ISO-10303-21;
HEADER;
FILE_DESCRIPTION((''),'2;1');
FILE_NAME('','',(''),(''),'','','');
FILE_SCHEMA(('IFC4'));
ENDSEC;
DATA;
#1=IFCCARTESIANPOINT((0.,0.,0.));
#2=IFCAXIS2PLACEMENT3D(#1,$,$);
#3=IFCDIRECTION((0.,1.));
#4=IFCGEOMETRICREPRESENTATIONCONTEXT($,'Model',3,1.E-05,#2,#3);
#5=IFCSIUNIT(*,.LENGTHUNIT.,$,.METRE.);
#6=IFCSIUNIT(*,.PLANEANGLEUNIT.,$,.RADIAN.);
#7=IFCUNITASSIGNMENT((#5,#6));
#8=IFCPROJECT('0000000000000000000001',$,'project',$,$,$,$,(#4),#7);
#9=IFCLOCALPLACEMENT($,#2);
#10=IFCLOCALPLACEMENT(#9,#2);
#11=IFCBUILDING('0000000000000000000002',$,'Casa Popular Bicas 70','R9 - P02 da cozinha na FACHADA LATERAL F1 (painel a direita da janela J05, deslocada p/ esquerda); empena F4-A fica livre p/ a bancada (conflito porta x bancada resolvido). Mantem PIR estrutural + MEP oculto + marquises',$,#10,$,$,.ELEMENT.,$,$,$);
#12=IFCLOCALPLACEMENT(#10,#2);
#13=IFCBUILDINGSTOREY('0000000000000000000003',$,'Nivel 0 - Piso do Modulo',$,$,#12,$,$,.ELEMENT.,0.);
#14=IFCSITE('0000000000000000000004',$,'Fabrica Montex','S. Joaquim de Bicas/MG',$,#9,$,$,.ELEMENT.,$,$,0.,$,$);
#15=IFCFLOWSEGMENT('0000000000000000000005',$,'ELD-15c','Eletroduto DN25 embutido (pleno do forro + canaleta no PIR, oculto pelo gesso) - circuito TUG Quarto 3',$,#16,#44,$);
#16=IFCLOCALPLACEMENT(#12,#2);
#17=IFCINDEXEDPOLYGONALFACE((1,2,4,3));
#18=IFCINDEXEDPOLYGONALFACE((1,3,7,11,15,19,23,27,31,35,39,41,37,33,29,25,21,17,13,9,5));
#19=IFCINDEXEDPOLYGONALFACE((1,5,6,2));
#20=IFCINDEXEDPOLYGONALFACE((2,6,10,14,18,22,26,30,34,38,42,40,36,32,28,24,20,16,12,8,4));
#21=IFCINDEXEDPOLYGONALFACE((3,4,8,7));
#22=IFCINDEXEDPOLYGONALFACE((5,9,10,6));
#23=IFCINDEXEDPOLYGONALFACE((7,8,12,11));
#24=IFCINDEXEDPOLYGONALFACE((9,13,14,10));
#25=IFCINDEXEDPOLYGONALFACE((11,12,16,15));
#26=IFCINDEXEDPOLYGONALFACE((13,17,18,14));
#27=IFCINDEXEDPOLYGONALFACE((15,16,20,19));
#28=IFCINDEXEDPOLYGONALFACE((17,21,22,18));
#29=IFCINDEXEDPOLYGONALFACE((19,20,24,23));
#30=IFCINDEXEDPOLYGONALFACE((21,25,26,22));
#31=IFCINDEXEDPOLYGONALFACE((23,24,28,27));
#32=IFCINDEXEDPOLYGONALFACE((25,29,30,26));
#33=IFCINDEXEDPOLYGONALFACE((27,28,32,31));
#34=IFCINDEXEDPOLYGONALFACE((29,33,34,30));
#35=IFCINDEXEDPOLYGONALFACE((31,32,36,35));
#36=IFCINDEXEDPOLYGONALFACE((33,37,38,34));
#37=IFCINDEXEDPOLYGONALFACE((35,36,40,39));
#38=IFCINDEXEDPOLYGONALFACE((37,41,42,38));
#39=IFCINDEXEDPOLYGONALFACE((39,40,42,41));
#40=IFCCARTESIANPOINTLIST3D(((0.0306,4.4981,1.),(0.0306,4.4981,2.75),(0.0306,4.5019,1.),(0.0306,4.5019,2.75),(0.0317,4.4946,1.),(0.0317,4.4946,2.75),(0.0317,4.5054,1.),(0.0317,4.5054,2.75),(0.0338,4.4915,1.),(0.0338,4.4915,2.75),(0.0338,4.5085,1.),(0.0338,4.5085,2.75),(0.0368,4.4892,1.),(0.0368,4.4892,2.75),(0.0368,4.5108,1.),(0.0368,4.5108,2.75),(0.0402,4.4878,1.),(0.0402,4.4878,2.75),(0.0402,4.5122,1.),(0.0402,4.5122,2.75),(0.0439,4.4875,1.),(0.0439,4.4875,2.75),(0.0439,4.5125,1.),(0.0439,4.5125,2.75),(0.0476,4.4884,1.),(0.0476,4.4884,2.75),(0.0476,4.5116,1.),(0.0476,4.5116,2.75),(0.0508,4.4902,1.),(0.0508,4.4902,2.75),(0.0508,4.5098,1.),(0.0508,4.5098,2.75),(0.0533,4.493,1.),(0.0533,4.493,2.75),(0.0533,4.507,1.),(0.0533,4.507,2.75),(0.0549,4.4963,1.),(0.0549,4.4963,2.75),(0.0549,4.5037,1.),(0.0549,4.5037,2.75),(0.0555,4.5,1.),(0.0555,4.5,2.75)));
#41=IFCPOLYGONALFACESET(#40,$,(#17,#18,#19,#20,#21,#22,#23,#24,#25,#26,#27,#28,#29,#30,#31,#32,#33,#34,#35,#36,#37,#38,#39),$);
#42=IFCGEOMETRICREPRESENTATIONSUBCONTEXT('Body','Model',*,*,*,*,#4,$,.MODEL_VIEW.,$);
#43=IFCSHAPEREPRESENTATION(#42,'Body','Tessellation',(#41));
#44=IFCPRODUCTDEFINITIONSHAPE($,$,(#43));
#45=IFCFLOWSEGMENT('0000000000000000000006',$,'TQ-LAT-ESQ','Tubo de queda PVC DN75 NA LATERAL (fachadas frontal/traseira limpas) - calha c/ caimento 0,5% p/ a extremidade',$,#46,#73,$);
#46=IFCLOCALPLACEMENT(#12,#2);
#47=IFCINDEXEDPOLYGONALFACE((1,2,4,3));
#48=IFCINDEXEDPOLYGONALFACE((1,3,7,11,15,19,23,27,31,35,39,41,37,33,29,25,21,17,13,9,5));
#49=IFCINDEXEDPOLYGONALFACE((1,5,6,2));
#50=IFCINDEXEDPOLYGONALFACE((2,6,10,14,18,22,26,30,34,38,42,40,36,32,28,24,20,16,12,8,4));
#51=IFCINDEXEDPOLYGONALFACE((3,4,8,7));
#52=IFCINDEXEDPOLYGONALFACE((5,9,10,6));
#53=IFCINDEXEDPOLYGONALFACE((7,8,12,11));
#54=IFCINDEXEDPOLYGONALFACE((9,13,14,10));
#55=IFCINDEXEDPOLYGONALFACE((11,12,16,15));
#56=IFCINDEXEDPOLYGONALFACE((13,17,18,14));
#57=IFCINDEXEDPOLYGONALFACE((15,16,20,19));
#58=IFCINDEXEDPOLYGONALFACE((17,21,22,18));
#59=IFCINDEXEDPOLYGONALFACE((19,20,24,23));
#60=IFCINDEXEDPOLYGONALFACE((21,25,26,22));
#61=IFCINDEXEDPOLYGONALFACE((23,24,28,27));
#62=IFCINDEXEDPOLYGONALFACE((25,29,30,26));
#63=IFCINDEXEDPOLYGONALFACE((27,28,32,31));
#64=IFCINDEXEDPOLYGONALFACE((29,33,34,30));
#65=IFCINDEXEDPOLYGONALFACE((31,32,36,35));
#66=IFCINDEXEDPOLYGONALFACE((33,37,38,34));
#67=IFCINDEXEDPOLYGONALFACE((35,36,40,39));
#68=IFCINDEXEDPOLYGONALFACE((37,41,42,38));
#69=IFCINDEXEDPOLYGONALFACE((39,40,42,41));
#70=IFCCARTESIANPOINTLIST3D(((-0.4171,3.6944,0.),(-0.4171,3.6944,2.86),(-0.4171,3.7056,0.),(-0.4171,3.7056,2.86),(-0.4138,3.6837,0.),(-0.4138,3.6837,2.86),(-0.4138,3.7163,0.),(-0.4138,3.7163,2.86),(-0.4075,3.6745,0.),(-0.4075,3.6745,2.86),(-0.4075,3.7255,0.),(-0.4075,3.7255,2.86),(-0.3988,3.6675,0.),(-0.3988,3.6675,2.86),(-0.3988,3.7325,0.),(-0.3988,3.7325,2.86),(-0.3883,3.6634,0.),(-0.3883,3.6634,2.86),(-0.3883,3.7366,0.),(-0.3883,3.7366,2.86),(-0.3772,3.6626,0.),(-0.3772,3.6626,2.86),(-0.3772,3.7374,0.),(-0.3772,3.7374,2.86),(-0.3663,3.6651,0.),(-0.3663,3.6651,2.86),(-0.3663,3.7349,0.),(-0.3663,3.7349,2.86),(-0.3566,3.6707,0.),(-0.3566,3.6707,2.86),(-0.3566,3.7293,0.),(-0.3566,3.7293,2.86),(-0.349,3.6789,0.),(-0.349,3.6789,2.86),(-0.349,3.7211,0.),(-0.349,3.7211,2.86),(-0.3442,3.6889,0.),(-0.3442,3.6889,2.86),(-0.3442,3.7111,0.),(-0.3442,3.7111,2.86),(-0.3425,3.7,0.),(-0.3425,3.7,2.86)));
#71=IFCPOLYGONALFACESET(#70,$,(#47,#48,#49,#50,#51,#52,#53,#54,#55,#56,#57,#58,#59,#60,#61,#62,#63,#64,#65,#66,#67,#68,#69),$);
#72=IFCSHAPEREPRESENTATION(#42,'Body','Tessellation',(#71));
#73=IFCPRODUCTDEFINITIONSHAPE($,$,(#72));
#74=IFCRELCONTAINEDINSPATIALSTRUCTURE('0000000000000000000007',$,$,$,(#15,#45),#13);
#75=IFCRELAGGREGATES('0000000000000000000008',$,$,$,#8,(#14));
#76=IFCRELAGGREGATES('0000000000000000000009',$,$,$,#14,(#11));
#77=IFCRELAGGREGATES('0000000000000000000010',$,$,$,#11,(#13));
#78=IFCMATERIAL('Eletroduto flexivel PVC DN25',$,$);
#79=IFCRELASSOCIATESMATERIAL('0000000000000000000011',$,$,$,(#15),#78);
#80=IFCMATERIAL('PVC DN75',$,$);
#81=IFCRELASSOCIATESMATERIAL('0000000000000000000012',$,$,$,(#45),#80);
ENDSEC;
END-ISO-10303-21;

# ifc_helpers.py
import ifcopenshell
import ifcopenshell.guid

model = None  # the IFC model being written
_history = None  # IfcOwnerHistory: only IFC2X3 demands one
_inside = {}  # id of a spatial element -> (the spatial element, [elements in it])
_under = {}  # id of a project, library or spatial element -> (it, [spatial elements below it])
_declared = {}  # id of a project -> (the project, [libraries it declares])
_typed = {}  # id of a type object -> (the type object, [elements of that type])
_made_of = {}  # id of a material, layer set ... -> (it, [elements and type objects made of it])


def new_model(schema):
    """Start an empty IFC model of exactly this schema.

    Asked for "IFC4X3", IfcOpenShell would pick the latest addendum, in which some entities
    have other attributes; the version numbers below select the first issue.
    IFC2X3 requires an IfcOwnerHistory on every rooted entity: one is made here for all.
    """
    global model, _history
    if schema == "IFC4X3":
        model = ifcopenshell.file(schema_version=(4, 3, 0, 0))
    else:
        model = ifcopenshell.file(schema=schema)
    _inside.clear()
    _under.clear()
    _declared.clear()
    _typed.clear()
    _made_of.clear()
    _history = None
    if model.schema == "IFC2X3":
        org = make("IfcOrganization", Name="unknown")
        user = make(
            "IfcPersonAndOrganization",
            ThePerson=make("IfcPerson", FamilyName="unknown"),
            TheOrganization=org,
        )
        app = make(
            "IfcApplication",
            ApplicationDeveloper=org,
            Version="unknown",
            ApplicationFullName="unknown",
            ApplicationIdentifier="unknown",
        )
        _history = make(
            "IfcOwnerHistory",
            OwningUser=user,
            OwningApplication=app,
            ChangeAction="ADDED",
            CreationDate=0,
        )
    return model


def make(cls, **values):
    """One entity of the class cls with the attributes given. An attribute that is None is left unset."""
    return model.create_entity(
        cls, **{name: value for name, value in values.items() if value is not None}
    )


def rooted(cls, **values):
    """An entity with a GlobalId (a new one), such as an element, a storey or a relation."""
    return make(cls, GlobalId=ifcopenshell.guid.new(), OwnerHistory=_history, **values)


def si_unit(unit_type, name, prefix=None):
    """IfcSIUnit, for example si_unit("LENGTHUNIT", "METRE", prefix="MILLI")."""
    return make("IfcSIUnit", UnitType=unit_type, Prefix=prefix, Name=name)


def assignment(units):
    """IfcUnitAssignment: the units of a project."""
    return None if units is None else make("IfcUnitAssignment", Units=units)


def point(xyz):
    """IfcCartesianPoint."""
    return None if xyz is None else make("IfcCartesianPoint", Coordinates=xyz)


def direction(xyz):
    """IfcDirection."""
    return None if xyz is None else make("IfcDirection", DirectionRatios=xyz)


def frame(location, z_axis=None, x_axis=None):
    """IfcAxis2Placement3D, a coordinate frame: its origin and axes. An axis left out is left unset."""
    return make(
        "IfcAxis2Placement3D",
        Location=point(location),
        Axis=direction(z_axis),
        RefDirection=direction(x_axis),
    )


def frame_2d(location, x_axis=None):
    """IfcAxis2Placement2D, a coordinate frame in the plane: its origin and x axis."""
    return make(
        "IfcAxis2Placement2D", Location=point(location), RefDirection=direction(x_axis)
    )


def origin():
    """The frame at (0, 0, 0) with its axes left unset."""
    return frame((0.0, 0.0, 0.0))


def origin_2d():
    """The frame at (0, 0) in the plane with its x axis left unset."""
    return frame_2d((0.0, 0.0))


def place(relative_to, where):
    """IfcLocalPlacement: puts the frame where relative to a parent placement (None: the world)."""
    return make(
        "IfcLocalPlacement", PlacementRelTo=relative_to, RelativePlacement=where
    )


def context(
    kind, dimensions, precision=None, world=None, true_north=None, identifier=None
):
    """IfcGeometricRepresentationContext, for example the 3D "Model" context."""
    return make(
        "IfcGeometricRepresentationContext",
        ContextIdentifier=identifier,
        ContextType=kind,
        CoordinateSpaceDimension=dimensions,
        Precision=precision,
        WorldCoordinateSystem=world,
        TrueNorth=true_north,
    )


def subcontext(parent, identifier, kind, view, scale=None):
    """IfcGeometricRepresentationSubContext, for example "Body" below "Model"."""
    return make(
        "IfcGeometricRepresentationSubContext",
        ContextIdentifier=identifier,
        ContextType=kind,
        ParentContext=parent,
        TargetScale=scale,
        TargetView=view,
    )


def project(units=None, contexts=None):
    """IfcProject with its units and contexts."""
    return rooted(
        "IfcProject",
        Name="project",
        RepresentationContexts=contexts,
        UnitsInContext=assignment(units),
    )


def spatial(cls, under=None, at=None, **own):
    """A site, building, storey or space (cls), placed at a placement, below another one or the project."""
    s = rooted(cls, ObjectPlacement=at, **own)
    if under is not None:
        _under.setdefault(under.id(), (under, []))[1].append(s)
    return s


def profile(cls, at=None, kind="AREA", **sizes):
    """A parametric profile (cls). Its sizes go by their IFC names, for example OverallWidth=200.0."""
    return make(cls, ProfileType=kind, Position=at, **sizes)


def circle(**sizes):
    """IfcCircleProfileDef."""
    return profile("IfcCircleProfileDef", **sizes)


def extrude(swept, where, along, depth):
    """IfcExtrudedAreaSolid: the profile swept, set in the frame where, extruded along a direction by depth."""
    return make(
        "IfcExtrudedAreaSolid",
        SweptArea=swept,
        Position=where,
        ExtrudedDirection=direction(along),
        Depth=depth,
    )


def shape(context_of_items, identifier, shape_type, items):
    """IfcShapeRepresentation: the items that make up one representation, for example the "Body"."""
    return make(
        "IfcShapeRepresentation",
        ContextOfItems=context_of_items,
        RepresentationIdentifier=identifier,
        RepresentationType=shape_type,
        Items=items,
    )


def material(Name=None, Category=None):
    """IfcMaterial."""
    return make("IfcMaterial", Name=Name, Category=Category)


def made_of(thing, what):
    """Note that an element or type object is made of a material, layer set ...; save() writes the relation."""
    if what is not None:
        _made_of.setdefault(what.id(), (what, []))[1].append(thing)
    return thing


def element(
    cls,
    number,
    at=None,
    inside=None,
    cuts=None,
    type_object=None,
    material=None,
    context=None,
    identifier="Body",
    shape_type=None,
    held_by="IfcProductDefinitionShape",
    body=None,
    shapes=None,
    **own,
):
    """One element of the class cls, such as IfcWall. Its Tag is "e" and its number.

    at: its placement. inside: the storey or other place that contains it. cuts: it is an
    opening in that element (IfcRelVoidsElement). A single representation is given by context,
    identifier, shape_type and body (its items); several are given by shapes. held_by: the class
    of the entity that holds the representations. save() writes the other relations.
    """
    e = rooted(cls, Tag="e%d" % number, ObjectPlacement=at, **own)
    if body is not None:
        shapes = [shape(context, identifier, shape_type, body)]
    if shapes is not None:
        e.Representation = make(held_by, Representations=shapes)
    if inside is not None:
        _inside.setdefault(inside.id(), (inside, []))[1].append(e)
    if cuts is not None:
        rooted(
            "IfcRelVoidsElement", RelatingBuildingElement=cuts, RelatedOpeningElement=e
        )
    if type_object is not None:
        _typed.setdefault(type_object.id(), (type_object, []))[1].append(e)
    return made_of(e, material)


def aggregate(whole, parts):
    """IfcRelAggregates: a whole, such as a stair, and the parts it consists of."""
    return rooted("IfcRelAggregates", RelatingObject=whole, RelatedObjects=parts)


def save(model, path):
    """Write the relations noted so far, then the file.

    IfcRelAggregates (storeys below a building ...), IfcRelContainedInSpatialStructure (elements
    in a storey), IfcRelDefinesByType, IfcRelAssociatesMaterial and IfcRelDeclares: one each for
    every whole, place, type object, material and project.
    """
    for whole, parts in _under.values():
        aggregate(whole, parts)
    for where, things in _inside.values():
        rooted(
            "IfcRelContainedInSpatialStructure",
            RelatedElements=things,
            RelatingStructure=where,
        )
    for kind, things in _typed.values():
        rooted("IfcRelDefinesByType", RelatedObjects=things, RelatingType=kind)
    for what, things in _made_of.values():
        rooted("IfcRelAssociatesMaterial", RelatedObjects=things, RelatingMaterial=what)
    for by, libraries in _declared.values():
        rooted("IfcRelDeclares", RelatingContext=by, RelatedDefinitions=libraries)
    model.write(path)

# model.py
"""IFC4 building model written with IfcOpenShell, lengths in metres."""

from ifc_helpers import new_model, si_unit, direction, frame, origin, origin_2d, place, context, subcontext, project, spatial, circle, extrude, material, element, save


model = new_model("IFC4")

# Units and contexts
model_context = context("Model", 3, precision=1e-05, world=origin(), true_north=direction((0.0, 1.0)))
body_context = subcontext(model_context, "Body", "Model", "MODEL_VIEW")
ifc_project = project(units=[si_unit("LENGTHUNIT", "METRE"), si_unit("PLANEANGLEUNIT", "RADIAN")], contexts=[model_context])

# Site, building, storey
site_placement = place(None, origin())
site = spatial("IfcSite", under=ifc_project, at=site_placement, Name="Fabrica Montex", Description="S. Joaquim de Bicas/MG", CompositionType="ELEMENT", RefElevation=0.0)
building_placement = place(site_placement, origin())
building = spatial("IfcBuilding", under=site, at=building_placement, Name="Casa Popular Bicas 70", Description="R9 - P02 da cozinha na FACHADA LATERAL F1 (painel a direita da janela J05, deslocada p/ esquerda); empena F4-A fica livre p/ a bancada (conflito porta x bancada resolvido). Mantem PIR estrutural + MEP oculto + marquises", CompositionType="ELEMENT")
storey_placement = place(building_placement, origin())
storey = spatial("IfcBuildingStorey", under=building, at=storey_placement, Name="Nivel 0 - Piso do Modulo", CompositionType="ELEMENT", Elevation=0.0)

# Flow segments
ifc_material_1 = material(Name="Eletroduto flexivel PVC DN25")
flow_segment_1_placement = place(storey_placement, frame((0.043, 4.5, 2.75), z_axis=(0.0, 0.0, -1.0), x_axis=(1.0, 0.0, 0.0)))
element("IfcFlowSegment", 1, at=flow_segment_1_placement, inside=storey, material=ifc_material_1, Name="ELD-15c", Description="Eletroduto DN25 embutido (pleno do forro + canaleta no PIR, oculto pelo gesso) - circuito TUG Quarto 3", context=body_context, shape_type="SweptSolid", body=[
    extrude(circle(Radius=0.0125, at=origin_2d()), origin(), (0.0, 0.0, 1.0), 1.75),
])
ifc_material_2 = material(Name="PVC DN75")
flow_segment_2_placement = place(storey_placement, frame((-0.38, 3.7, 0.0)))
element("IfcFlowSegment", 2, at=flow_segment_2_placement, inside=storey, material=ifc_material_2, Name="TQ-LAT-ESQ", Description="Tubo de queda PVC DN75 NA LATERAL (fachadas frontal/traseira limpas) - calha c/ caimento 0,5% p/ a extremidade", context=body_context, shape_type="SweptSolid", body=[
    extrude(circle(Radius=0.0375, at=origin_2d()), origin(), (0.0, 0.0, 1.0), 2.86),
])

save(model, "model.ifc")
